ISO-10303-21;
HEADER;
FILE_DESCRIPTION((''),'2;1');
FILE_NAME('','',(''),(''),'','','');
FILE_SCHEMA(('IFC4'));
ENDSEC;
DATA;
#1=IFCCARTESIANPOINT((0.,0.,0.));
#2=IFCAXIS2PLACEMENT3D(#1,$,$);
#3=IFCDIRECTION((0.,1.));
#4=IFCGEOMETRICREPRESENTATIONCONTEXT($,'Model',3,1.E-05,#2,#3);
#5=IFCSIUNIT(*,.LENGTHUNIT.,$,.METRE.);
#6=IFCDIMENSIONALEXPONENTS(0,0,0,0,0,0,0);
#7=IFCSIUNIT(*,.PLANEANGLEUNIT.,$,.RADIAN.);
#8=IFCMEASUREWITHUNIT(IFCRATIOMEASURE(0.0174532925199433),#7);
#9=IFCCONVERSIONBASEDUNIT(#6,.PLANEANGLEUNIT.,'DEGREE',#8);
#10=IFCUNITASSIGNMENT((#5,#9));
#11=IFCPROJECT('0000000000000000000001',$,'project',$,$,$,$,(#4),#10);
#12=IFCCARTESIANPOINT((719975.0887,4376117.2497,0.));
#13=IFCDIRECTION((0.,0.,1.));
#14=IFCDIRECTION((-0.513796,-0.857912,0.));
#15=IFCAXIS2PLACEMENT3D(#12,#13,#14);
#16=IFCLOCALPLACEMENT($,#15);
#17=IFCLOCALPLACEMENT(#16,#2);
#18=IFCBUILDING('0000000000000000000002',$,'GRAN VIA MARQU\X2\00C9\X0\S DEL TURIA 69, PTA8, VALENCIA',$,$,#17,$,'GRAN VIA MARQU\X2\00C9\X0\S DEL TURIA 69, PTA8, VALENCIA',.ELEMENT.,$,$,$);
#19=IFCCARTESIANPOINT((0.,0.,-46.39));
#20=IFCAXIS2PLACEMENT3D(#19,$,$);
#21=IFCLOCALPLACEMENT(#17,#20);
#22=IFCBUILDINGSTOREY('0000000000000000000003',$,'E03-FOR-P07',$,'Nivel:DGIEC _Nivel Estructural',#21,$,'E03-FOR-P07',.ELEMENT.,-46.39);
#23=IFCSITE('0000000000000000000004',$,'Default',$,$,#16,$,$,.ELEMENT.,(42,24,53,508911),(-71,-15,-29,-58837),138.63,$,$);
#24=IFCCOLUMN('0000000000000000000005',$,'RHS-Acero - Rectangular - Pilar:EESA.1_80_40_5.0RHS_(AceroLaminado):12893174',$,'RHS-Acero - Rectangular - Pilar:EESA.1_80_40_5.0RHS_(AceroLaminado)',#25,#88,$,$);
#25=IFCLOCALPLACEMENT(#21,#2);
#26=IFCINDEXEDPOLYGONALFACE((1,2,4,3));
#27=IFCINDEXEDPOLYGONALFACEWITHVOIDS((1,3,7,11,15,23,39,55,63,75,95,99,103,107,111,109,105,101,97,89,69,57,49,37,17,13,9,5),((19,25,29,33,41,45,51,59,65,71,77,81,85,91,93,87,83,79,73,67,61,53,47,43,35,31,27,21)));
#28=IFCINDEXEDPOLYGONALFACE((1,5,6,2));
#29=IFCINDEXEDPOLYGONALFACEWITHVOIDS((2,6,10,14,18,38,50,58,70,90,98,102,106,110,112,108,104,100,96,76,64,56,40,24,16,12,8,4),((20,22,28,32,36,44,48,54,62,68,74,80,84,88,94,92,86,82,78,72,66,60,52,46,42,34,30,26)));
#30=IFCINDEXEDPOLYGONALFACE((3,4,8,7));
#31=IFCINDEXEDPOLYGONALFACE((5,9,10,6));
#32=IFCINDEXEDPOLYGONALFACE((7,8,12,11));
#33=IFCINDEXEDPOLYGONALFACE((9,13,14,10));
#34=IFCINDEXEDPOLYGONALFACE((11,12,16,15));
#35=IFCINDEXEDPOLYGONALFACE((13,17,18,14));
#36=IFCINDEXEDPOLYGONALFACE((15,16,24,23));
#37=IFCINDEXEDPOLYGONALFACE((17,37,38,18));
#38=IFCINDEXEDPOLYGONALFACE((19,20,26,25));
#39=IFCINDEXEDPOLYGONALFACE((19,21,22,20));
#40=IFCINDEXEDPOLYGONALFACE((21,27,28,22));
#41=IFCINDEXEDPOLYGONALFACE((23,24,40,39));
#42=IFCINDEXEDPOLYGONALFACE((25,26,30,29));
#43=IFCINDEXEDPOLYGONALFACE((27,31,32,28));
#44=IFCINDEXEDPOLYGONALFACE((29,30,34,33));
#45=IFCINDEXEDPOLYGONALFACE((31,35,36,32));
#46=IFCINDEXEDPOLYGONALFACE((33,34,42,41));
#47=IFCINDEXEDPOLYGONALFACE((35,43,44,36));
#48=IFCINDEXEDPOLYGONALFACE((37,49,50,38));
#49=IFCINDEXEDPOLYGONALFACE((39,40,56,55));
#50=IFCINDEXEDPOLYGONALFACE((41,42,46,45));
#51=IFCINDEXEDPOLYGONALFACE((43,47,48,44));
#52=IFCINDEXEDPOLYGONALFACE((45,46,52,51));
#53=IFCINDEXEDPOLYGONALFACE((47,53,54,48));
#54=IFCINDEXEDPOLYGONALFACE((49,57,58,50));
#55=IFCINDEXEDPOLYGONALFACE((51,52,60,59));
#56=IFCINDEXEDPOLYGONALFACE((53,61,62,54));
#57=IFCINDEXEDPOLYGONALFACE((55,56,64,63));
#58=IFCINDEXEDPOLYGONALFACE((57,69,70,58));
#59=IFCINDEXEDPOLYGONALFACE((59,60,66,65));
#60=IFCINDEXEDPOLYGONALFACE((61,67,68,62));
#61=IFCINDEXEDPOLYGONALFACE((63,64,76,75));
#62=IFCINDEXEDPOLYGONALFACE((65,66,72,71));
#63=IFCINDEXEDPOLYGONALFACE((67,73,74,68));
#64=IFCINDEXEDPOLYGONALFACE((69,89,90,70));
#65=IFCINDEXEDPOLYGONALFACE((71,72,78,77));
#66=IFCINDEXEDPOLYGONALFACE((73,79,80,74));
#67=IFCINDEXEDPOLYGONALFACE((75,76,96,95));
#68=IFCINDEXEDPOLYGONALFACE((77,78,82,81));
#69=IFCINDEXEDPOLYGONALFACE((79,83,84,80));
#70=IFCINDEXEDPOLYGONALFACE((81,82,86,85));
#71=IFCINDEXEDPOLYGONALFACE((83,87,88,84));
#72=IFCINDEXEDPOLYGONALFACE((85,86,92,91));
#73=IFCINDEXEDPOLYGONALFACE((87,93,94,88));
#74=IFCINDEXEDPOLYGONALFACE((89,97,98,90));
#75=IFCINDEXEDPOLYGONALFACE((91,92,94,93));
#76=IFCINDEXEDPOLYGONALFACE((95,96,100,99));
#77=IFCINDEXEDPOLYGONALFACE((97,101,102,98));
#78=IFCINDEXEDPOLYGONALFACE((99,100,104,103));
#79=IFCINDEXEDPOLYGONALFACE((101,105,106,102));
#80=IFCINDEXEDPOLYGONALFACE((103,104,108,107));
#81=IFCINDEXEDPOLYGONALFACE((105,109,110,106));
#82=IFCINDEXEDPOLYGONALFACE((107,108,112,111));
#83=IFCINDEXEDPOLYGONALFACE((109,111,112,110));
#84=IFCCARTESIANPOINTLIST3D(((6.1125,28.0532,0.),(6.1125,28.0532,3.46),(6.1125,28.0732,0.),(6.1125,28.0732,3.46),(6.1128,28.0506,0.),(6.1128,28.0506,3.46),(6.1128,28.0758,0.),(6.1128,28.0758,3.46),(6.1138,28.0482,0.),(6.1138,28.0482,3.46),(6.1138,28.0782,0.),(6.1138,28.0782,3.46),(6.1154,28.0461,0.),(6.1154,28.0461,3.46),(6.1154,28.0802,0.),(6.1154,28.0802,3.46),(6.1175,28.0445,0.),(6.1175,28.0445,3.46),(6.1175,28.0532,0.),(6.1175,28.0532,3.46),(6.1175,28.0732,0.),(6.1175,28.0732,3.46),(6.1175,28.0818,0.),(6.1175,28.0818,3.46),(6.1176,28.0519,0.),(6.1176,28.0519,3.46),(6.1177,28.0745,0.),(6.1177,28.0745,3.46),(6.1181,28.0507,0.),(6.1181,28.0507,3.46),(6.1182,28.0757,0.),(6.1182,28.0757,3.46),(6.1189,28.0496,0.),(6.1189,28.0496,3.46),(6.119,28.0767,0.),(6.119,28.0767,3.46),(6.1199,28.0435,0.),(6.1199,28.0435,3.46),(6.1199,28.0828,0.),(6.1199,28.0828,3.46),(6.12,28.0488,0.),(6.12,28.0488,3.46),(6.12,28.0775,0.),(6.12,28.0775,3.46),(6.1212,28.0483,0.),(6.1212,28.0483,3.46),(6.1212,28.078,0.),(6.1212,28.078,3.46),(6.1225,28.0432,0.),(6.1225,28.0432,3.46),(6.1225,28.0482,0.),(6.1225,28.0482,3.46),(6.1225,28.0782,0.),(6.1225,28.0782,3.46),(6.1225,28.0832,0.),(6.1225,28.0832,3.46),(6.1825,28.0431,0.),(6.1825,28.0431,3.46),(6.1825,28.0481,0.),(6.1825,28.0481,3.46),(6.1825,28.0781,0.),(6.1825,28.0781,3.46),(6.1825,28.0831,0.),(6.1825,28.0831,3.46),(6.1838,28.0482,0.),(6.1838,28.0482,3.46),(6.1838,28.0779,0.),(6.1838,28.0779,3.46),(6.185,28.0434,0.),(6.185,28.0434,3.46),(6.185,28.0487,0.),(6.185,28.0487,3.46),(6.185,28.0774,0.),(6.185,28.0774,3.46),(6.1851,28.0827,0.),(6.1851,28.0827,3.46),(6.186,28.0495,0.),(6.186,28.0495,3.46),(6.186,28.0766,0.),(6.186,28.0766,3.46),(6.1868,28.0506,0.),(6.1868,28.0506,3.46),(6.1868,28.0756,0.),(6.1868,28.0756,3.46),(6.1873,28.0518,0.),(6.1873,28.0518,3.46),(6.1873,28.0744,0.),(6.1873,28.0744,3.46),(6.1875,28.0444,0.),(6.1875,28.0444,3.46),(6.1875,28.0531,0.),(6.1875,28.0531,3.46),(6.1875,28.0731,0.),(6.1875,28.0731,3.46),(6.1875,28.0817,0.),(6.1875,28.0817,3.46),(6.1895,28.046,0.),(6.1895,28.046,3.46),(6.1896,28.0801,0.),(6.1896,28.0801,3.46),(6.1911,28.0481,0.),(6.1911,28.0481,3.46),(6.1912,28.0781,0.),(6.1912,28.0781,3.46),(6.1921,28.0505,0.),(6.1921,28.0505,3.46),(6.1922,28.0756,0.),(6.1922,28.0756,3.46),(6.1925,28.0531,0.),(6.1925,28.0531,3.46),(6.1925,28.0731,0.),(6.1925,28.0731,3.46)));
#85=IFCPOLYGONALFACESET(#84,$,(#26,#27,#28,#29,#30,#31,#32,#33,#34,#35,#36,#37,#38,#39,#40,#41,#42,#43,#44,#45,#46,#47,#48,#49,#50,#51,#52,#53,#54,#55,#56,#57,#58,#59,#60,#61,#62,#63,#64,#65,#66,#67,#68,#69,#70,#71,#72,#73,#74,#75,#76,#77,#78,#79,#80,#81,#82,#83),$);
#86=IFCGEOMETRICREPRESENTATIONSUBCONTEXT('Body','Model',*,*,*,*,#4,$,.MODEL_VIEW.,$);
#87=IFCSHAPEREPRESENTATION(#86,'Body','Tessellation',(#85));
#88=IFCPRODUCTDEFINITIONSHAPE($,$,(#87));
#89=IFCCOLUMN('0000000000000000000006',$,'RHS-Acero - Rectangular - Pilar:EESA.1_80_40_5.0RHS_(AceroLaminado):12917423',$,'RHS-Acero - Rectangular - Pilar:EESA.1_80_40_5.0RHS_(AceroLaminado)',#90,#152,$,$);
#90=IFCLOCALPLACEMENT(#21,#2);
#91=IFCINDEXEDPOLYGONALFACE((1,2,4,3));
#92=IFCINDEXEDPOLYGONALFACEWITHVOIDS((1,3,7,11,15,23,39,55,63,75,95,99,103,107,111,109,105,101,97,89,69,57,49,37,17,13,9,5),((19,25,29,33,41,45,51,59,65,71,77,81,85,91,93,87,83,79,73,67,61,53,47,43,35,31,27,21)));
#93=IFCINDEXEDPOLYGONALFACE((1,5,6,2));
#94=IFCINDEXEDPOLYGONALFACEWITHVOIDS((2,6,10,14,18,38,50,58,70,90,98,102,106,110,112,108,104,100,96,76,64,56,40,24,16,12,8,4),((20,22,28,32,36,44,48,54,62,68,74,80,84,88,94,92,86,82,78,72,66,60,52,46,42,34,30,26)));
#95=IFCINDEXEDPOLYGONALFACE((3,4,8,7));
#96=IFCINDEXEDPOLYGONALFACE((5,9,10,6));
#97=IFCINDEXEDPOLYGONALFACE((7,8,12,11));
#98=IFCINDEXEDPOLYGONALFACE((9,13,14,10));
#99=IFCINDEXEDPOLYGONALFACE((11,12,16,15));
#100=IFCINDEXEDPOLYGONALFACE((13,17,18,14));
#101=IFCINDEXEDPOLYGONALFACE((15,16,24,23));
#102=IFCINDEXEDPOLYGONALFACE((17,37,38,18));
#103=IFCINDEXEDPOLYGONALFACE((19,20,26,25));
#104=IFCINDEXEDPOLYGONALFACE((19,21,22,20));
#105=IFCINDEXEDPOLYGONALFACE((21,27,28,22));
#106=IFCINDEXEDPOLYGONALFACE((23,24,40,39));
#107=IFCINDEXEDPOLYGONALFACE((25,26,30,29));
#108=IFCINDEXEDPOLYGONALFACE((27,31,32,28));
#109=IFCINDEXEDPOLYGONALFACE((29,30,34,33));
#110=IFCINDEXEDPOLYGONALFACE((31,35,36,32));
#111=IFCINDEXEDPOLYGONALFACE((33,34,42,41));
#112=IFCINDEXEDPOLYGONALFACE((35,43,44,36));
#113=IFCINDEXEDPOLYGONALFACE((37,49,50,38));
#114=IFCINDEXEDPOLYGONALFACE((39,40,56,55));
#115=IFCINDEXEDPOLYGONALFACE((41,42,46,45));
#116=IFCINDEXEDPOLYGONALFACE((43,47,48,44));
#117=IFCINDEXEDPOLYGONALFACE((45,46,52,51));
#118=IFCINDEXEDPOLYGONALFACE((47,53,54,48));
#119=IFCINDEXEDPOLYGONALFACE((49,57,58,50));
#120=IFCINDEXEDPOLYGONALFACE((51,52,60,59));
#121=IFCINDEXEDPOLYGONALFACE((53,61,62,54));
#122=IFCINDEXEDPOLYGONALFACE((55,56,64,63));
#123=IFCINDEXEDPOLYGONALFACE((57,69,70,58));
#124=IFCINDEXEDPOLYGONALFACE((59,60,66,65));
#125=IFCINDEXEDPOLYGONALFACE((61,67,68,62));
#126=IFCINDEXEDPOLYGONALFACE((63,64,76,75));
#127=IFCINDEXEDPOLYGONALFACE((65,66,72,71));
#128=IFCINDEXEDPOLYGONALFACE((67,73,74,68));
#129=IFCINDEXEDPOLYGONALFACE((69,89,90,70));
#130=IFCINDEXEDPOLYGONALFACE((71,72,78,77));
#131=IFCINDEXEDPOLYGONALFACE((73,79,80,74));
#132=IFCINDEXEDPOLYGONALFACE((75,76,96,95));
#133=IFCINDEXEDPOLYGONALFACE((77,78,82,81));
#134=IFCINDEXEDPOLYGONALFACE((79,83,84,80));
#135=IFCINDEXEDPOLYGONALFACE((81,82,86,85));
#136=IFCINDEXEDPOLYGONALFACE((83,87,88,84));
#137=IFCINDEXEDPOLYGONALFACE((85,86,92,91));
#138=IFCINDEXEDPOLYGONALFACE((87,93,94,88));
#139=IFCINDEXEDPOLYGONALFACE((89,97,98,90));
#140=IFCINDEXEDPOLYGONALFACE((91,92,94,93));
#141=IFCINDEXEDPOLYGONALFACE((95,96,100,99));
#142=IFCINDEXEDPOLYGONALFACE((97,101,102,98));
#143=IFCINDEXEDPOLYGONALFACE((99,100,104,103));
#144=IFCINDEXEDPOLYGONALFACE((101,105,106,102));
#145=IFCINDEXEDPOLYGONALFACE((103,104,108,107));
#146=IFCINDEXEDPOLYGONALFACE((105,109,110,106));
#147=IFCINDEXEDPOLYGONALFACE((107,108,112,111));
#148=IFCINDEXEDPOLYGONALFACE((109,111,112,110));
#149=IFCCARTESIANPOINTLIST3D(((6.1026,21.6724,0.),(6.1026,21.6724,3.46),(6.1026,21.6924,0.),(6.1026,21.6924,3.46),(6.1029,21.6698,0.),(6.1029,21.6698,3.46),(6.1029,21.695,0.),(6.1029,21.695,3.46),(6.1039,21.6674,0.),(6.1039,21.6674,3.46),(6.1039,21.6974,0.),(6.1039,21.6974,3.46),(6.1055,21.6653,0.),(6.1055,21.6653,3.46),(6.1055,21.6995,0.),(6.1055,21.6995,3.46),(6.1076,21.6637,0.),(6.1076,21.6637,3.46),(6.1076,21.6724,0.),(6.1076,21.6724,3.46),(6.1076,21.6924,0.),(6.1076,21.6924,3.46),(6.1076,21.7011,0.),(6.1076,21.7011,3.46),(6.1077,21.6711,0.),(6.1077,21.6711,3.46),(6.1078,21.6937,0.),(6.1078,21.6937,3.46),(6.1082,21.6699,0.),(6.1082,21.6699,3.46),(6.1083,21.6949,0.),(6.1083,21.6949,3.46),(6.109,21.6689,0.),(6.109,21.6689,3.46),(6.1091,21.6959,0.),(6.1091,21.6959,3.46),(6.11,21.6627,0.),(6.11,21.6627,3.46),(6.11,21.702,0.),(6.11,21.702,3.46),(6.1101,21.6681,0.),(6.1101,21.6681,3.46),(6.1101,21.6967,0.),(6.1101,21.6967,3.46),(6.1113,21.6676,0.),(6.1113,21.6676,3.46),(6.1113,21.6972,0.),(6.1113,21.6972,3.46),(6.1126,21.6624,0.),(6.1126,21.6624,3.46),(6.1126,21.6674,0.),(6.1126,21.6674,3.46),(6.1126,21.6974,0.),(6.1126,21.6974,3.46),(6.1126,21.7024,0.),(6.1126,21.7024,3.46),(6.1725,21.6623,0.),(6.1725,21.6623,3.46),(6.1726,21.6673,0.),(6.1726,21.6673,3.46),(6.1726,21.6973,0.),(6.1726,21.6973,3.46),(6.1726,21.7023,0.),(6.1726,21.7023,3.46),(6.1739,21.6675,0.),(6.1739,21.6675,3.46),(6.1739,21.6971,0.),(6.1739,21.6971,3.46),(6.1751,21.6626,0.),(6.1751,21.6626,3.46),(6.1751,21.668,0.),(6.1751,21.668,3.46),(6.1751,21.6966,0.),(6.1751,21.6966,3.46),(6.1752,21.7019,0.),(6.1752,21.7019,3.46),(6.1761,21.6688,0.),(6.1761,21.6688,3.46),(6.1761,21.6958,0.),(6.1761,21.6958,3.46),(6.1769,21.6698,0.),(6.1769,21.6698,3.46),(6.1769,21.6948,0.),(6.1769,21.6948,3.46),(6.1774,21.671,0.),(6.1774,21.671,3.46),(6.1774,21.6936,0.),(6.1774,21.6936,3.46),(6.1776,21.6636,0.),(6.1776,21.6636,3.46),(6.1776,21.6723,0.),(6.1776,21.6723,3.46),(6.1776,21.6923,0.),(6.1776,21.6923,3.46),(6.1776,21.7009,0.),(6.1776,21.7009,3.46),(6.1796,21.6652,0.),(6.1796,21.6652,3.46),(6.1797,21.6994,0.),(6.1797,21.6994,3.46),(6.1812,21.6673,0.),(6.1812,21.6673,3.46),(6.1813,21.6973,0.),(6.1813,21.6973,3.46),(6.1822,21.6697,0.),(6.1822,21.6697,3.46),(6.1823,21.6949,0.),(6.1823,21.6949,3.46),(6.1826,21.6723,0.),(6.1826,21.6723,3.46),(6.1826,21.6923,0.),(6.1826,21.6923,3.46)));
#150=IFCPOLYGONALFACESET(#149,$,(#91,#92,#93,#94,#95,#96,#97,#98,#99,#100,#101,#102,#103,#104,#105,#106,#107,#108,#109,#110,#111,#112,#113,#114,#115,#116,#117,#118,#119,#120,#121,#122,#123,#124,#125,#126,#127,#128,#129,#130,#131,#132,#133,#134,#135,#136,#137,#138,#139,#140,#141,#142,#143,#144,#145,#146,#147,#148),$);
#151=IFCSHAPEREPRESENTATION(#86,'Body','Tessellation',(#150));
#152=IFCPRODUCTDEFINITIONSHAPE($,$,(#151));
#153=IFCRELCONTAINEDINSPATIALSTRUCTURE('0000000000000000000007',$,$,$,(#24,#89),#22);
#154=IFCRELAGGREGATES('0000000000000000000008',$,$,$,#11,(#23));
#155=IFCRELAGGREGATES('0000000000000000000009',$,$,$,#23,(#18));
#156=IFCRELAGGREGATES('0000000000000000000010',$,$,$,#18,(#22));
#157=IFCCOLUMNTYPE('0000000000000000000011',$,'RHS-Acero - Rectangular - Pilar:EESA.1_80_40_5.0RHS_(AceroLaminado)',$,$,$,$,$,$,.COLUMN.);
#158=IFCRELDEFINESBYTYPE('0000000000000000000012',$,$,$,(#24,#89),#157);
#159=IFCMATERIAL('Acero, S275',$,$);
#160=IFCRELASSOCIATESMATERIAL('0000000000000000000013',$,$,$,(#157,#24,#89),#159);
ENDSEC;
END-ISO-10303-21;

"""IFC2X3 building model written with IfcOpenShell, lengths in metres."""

from ifc_helpers import new_model, entity, si_unit, converted_unit, direction, frame, frame_2d, origin, place, context, subcontext, project, spatial, polyline, circle_curve, parameter, trimmed, segment, composite_curve, outline, extrude, source, transform, mapped, material, type_object, type_shapes, element, save


model = new_model("IFC2X3")

# Units and contexts
model_context = context("Model", 3, precision=1e-05, world=origin(), true_north=direction((0.0, 1.0)))
body_context = subcontext(model_context, "Body", "Model", "MODEL_VIEW")
ifc_project = project(units=[si_unit("LENGTHUNIT", "METRE"), converted_unit("PLANEANGLEUNIT", "DEGREE", entity("IfcRatioMeasure", 0.0174532925199433), si_unit("PLANEANGLEUNIT", "RADIAN"), dimensions=[0, 0, 0, 0, 0, 0, 0])], contexts=[model_context])

# Site, building, storey
site_placement = place(None, frame((719975.0887, 4376117.2497, 0.0), z_axis=(0.0, 0.0, 1.0), x_axis=(-0.513796, -0.857912, 0.0)))
site = spatial("IfcSite", under=ifc_project, at=site_placement, Name="Default", CompositionType="ELEMENT", RefLatitude=(42, 24, 53, 508911), RefLongitude=(-71, -15, -29, -58837), RefElevation=138.63)
building_placement = place(site_placement, origin())
building = spatial("IfcBuilding", under=site, at=building_placement, Name="GRAN VIA MARQUÉS DEL TURIA 69, PTA8, VALENCIA", LongName="GRAN VIA MARQUÉS DEL TURIA 69, PTA8, VALENCIA", CompositionType="ELEMENT")
storey_placement = place(building_placement, frame((0.0, 0.0, -46.39)))
storey = spatial("IfcBuildingStorey", under=building, at=storey_placement, Name="E03-FOR-P07", ObjectType="Nivel:DGIEC _Nivel Estructural", LongName="E03-FOR-P07", CompositionType="ELEMENT", Elevation=-46.39)

# Columns
ifc_material = material(Name="Acero, S275")
column_type_1 = type_object("IfcColumnType", Name="RHS-Acero - Rectangular - Pilar:EESA.1_80_40_5.0RHS_(AceroLaminado)", PredefinedType="COLUMN", material=ifc_material)
shared_shape_1 = source(origin(), body_context, "Body", "SweptSolid", [
    extrude(outline(composite_curve([segment(polyline([(-0.01, -0.04), (0.01, -0.04)]), True, "CONTINUOUS"), segment(trimmed(circle_curve(frame_2d((0.01, -0.03), x_axis=(-1.0, 0.0)), 0.01), [parameter(90.0)], [parameter(180.0)], True, "PARAMETER"), True, "CONTINUOUS"), segment(polyline([(0.02, -0.03), (0.02, 0.03)]), True, "CONTINUOUS"), segment(trimmed(circle_curve(frame_2d((0.01, 0.03), x_axis=(-1.0, 0.0)), 0.01), [parameter(180.0)], [parameter(270.0)], True, "PARAMETER"), True, "CONTINUOUS"), segment(polyline([(0.01, 0.04), (-0.01, 0.04)]), True, "CONTINUOUS"), segment(trimmed(circle_curve(frame_2d((-0.01, 0.03), x_axis=(-1.0, 0.0)), 0.01), [parameter(270.0)], [parameter(360.0)], True, "PARAMETER"), True, "CONTINUOUS"), segment(polyline([(-0.02, 0.03), (-0.02, -0.03)]), True, "CONTINUOUS"), segment(trimmed(circle_curve(frame_2d((-0.01, -0.03), x_axis=(-1.0, 0.0)), 0.01), [parameter(360.0)], [parameter(90.0)], True, "PARAMETER"), True, "CONTINUOUS")], self_intersect=False), holes=[composite_curve([segment(trimmed(circle_curve(frame_2d((-0.01, -0.03), x_axis=(-1.0, 0.0)), 0.005), [parameter(0.0)], [parameter(90.0)], True, "PARAMETER"), False, "CONTINUOUS"), segment(polyline([(-0.015, -0.03), (-0.015, 0.03)]), True, "CONTINUOUS"), segment(trimmed(circle_curve(frame_2d((-0.01, 0.03), x_axis=(-1.0, 0.0)), 0.005), [parameter(270.0)], [parameter(0.0)], True, "PARAMETER"), False, "CONTINUOUS"), segment(polyline([(-0.01, 0.035), (0.01, 0.035)]), True, "CONTINUOUS"), segment(trimmed(circle_curve(frame_2d((0.01, 0.03), x_axis=(-1.0, 0.0)), 0.005), [parameter(180.0)], [parameter(270.0)], True, "PARAMETER"), False, "CONTINUOUS"), segment(polyline([(0.015, 0.03), (0.015, -0.03)]), True, "CONTINUOUS"), segment(trimmed(circle_curve(frame_2d((0.01, -0.03), x_axis=(-1.0, 0.0)), 0.005), [parameter(90.0)], [parameter(180.0)], True, "PARAMETER"), False, "CONTINUOUS"), segment(polyline([(0.01, -0.035), (-0.01, -0.035)]), True, "CONTINUOUS")], self_intersect=False)]), frame((0.0, 0.0, -46.39), z_axis=(0.0, 0.0, 1.0), x_axis=(-1.0, 0.0, 0.0)), (0.0, 0.0, 1.0), 3.46),
])
type_shapes(column_type_1, [shared_shape_1])
for number, where, z_axis, x_axis, name in (
    (1, (6.1525, 28.0631, 46.39), (0.0, 0.0, 1.0), (0.001552, 0.999999, 0.0), "RHS-Acero - Rectangular - Pilar:EESA.1_80_40_5.0RHS_(AceroLaminado):12893174"),
    (2, (6.1426, 21.6823, 46.39), (0.0, 0.0, 1.0), (0.001552, 0.999999, 0.0), "RHS-Acero - Rectangular - Pilar:EESA.1_80_40_5.0RHS_(AceroLaminado):12917423"),
):
    element("IfcColumn", number, at=place(storey_placement, frame(where, z_axis=z_axis, x_axis=x_axis)), inside=storey, type_object=column_type_1, material=ifc_material, Name=name, ObjectType="RHS-Acero - Rectangular - Pilar:EESA.1_80_40_5.0RHS_(AceroLaminado)", context=body_context, shape_type="MappedRepresentation", body=[
        mapped(shared_shape_1, transform((0.0, 0.0, 0.0), scale=1.0)),
    ])

save(model, "model.ifc")
